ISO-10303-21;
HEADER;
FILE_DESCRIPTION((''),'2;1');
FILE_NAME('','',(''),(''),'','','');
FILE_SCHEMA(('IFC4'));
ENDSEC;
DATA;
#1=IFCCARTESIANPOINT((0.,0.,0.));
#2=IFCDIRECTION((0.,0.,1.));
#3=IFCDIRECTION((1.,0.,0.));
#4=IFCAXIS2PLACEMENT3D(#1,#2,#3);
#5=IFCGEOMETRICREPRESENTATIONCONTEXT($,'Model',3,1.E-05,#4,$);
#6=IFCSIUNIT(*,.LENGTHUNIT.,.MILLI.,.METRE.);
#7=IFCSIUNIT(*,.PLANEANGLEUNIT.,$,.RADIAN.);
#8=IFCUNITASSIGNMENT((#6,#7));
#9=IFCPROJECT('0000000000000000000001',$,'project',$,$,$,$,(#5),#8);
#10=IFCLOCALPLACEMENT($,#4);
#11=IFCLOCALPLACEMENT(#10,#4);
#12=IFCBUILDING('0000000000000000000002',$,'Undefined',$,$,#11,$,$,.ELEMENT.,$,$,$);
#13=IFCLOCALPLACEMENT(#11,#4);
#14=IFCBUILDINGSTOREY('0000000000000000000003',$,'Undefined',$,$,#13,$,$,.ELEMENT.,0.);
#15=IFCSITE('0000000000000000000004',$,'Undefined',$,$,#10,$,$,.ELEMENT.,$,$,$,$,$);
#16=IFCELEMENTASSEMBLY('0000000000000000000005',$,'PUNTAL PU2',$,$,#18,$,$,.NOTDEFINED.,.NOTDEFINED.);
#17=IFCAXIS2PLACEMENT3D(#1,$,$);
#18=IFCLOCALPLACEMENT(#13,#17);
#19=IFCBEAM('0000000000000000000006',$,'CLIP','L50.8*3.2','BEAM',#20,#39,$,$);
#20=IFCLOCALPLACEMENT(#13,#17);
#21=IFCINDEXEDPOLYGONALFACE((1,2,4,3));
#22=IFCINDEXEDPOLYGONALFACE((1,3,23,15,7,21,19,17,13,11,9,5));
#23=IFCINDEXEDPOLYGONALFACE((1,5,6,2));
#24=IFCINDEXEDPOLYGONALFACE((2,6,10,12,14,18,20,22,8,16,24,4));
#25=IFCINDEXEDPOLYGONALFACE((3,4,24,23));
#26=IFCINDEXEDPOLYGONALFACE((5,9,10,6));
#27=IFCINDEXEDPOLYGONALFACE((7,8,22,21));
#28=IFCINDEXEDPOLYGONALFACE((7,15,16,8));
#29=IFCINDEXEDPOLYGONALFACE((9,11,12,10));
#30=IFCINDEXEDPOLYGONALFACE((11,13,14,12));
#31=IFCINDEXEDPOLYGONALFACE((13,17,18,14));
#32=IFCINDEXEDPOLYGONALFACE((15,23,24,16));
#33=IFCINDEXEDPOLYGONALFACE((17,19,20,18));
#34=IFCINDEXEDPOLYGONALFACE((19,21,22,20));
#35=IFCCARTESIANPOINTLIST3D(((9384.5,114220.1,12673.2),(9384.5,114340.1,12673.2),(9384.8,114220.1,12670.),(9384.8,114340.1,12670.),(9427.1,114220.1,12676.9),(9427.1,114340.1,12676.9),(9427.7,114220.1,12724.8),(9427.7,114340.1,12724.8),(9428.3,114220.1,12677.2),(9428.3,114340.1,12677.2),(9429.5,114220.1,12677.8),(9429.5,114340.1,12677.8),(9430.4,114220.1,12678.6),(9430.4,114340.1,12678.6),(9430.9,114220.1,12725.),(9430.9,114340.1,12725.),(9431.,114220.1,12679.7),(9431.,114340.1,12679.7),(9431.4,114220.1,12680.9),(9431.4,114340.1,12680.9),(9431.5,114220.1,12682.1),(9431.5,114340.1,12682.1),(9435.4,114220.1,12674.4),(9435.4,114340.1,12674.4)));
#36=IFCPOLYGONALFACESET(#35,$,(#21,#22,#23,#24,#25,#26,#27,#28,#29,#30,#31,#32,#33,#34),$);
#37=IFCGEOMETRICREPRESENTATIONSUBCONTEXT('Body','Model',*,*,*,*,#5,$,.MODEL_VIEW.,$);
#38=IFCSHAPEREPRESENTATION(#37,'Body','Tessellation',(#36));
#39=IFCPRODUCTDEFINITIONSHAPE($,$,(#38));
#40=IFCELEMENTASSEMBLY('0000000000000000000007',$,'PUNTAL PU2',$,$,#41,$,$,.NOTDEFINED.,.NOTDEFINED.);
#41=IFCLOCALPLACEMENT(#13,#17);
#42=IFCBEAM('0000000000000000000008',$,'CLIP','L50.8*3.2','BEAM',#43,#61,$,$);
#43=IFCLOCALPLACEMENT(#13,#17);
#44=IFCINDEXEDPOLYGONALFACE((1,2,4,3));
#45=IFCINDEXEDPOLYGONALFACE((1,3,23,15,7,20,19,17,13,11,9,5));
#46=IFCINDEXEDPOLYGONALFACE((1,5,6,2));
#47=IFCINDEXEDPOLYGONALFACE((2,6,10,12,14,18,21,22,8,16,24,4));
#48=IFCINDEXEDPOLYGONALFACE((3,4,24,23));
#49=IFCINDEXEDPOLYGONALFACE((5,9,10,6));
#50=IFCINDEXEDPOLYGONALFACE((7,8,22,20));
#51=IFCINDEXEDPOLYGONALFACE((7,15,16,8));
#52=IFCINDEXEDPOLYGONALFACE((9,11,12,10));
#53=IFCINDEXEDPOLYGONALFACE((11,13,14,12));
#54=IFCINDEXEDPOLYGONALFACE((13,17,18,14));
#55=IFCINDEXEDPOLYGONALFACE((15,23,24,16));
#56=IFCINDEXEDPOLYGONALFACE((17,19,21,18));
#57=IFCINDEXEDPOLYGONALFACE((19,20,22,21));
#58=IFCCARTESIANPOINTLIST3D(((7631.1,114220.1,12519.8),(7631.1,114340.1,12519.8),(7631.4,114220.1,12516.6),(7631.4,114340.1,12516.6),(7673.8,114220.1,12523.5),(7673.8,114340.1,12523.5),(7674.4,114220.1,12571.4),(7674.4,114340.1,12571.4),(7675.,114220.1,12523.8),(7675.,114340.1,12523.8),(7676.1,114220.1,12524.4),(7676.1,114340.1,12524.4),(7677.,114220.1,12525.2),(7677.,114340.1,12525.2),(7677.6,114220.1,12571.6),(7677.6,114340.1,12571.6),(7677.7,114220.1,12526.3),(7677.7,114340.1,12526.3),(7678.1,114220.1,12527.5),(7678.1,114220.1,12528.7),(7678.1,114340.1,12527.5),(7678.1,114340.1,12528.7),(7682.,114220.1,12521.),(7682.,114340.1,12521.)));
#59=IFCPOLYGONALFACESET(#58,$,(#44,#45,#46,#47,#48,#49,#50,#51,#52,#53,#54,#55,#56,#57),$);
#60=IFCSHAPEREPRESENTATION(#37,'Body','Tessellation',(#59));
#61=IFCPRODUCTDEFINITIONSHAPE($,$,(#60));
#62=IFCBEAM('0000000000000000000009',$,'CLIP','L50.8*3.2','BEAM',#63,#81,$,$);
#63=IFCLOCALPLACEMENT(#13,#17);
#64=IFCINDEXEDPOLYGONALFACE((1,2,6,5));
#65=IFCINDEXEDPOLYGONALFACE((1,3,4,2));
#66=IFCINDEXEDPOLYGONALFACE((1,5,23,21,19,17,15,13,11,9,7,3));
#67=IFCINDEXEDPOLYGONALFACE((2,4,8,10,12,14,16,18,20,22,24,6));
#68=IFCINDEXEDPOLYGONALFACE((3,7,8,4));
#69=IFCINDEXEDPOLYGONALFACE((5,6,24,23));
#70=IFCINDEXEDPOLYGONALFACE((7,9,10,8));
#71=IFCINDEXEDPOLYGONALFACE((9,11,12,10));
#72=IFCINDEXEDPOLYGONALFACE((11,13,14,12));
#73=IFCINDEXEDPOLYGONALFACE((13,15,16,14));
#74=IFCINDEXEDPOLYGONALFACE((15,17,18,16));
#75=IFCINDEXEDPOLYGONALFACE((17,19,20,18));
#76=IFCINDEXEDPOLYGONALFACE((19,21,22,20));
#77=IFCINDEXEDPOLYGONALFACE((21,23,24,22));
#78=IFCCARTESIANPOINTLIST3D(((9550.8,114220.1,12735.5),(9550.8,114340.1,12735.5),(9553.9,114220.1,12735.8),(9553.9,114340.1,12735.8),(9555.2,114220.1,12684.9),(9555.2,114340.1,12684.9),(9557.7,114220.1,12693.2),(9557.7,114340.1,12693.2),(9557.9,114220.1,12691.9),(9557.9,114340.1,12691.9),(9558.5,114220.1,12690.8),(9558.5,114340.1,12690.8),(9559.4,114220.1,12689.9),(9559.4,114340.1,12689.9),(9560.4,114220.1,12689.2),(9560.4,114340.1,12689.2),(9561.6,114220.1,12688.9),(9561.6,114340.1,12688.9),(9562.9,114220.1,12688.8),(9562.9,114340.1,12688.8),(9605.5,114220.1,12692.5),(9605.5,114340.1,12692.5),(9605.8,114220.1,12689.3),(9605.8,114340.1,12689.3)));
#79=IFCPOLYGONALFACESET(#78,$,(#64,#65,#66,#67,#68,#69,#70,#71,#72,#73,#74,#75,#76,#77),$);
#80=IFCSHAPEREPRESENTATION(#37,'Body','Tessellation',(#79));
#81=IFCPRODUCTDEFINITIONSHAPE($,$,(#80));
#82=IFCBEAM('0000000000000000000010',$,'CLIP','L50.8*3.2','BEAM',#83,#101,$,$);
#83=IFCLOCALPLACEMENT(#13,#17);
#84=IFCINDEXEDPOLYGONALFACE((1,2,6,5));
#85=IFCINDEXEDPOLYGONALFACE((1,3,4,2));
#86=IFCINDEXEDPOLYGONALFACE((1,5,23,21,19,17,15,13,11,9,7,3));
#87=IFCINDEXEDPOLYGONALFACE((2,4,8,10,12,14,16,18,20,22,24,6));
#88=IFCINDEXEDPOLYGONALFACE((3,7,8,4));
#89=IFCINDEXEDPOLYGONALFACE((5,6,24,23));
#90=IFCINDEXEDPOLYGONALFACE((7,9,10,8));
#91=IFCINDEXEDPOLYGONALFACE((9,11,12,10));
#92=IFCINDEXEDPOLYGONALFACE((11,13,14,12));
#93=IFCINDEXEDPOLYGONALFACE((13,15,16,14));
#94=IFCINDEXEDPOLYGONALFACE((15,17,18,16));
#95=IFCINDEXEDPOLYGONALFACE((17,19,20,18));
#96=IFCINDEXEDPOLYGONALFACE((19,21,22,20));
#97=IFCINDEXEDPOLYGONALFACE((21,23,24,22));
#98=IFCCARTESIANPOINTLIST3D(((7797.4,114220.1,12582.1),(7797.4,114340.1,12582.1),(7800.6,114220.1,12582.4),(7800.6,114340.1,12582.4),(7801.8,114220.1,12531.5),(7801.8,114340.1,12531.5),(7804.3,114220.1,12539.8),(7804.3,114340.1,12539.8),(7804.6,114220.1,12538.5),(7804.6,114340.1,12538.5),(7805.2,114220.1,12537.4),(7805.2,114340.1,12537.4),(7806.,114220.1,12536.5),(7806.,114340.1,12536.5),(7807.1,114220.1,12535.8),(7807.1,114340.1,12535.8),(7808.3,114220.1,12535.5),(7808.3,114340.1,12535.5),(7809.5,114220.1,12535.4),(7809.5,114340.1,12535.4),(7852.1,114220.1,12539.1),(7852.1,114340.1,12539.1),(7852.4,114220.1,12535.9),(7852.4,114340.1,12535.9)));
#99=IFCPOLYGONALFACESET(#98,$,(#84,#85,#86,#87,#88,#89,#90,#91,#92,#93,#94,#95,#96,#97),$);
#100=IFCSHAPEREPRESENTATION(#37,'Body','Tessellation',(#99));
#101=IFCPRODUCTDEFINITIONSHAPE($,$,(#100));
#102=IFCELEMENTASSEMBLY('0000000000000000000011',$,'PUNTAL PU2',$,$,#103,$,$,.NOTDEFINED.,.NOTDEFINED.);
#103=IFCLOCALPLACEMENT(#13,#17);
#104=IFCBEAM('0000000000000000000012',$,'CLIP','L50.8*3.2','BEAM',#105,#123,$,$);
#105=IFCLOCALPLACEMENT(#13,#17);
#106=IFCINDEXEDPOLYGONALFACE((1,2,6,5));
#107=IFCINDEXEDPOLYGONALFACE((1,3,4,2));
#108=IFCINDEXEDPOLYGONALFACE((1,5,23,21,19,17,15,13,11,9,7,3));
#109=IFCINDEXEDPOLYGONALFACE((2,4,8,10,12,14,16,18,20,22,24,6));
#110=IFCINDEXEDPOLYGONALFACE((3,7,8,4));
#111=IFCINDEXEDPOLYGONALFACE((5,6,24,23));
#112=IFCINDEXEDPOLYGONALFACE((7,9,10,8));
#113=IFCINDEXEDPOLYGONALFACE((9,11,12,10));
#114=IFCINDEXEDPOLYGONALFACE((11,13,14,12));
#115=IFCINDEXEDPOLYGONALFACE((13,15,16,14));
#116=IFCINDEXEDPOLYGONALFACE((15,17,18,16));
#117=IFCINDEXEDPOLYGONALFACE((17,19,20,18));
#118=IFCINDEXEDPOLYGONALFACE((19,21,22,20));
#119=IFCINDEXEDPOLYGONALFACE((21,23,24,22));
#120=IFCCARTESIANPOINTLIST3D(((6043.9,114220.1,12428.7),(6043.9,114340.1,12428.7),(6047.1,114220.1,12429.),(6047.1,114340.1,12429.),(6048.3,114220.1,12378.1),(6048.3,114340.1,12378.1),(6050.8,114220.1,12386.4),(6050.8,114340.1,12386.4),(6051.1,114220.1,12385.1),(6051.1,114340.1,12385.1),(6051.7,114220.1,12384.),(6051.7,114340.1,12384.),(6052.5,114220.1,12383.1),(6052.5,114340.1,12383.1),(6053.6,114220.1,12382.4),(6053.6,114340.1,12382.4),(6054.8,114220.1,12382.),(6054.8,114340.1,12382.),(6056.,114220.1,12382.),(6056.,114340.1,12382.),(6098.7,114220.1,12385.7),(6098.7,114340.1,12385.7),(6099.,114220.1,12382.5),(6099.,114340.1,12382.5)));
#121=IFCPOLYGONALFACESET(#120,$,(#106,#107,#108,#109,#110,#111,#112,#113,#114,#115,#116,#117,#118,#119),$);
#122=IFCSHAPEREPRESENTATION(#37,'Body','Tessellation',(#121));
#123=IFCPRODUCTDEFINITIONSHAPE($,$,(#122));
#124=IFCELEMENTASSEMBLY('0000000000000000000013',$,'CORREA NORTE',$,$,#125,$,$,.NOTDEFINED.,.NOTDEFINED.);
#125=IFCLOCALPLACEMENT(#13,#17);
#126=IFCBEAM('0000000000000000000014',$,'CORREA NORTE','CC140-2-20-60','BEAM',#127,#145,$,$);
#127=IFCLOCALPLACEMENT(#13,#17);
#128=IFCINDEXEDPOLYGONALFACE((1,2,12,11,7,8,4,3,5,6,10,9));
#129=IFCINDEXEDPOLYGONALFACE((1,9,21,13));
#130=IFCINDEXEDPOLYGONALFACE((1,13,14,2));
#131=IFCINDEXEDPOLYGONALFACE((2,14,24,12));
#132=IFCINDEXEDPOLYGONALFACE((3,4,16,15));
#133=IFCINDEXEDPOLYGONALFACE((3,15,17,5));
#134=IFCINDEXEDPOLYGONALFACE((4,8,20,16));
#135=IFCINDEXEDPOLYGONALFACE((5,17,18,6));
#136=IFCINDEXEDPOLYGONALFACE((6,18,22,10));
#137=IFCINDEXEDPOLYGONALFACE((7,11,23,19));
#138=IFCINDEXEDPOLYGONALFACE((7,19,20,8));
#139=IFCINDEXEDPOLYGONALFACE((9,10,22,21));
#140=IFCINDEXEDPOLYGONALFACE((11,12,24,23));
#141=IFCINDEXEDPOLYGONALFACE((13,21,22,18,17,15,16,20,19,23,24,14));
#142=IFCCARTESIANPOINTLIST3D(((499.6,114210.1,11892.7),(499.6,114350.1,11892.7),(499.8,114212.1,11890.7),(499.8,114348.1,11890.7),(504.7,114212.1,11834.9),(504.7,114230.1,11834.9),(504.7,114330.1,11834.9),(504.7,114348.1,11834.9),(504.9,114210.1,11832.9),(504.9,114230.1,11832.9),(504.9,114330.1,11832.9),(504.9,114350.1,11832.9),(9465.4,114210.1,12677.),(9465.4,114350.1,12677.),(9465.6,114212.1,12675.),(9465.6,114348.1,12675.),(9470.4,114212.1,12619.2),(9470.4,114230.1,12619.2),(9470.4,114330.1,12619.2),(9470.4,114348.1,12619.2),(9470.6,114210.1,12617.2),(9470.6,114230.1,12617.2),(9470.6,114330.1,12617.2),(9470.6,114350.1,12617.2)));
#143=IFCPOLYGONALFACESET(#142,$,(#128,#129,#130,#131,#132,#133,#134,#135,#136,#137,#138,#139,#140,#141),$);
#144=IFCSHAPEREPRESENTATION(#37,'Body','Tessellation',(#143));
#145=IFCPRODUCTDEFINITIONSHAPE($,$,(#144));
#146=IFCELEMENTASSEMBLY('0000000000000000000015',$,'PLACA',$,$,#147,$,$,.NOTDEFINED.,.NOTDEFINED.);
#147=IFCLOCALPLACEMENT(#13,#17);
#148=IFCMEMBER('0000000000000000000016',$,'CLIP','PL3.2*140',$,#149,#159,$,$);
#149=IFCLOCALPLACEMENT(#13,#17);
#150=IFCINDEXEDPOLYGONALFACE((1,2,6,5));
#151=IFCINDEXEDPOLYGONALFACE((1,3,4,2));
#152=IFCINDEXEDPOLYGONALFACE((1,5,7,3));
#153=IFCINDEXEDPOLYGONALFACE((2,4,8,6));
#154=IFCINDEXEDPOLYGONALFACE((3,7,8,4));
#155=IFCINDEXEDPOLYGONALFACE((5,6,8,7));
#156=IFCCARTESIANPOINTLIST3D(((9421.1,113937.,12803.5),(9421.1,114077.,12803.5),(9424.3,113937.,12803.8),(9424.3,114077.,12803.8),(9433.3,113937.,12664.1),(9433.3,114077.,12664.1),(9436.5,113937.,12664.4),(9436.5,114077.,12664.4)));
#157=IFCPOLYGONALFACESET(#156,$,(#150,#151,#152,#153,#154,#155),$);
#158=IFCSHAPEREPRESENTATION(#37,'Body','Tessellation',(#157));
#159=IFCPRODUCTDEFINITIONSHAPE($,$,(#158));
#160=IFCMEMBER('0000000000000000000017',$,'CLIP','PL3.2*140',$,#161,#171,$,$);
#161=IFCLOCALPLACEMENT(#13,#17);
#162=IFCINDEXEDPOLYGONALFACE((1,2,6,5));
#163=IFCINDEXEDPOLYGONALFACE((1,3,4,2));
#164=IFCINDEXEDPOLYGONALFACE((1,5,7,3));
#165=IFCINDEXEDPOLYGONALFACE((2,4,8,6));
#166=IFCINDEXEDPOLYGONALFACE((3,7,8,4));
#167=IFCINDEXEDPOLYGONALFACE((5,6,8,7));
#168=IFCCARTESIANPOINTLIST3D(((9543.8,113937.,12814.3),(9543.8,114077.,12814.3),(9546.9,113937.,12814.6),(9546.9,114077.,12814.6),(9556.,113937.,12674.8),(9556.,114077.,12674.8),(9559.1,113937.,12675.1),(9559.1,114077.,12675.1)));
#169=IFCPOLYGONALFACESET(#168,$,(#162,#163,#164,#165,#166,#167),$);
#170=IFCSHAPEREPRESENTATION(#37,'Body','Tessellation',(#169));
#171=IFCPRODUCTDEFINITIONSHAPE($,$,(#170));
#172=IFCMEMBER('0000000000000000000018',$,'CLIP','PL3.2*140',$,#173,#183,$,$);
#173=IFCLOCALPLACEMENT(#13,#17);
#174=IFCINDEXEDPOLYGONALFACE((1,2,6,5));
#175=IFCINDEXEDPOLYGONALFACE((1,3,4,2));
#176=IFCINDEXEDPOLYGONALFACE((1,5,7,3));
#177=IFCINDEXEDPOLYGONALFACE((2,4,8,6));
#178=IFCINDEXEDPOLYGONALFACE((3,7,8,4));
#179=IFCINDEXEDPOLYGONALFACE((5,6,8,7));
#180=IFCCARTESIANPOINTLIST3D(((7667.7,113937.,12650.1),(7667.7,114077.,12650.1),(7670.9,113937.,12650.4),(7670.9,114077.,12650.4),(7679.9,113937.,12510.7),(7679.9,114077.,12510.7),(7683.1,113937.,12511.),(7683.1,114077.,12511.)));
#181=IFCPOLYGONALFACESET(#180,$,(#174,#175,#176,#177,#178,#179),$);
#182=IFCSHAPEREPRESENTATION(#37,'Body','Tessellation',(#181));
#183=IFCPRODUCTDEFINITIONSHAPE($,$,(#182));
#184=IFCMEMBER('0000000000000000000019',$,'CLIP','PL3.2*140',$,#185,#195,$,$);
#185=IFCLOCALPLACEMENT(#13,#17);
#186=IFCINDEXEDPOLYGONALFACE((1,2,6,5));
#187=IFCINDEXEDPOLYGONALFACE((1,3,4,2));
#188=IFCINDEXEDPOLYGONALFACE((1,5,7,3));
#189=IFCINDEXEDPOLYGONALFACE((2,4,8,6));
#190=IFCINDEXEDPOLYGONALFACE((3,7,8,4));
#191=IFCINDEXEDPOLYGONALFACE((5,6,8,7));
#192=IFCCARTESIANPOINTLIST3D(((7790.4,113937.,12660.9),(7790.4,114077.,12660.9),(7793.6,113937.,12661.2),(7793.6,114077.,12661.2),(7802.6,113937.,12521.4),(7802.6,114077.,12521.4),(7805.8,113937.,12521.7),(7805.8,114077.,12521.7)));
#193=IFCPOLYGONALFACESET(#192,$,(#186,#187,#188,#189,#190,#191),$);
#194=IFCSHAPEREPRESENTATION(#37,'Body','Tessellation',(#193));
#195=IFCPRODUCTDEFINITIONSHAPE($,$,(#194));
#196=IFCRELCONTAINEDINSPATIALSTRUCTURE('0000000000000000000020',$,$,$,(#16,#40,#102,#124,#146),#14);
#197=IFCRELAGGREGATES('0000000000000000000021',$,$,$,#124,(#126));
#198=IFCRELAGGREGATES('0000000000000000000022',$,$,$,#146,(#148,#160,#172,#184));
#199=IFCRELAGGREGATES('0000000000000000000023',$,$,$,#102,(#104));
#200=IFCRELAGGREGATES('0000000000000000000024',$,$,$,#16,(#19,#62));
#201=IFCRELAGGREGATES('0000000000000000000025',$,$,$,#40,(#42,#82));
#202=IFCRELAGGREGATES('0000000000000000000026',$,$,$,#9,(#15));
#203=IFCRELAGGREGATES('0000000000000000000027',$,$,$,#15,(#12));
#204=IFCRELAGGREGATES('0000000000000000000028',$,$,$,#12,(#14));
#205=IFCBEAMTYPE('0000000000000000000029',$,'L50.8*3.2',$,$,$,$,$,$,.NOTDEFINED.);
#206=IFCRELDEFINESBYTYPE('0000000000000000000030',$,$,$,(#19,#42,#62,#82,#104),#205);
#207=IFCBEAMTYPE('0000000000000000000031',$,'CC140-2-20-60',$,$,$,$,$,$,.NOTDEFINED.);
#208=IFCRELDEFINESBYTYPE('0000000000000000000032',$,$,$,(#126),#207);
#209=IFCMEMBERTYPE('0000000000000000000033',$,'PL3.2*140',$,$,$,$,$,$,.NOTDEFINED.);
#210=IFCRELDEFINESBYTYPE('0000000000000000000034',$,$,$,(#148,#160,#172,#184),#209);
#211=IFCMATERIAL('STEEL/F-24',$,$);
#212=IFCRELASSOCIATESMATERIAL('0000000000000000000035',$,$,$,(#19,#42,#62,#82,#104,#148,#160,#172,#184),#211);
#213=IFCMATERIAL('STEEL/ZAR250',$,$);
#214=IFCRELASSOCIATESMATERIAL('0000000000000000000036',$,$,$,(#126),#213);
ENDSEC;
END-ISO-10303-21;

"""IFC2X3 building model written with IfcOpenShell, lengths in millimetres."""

from ifc_helpers import new_model, si_unit, frame, origin_with_axes, origin_2d_with_axis, place, context, subcontext, project, spatial, rectangle, l_section, c_section, extrude, material, type_object, element, aggregate, save


model = new_model("IFC2X3")

# Units and contexts
model_context = context("Model", 3, precision=1e-05, world=origin_with_axes())
body_context = subcontext(model_context, "Body", "Model", "MODEL_VIEW")
ifc_project = project(units=[si_unit("LENGTHUNIT", "METRE", prefix="MILLI"), si_unit("PLANEANGLEUNIT", "RADIAN")], contexts=[model_context])

# Site, building, storey
site_placement = place(None, origin_with_axes())
site = spatial("IfcSite", under=ifc_project, at=site_placement, Name="Undefined", CompositionType="ELEMENT")
building_placement = place(site_placement, origin_with_axes())
building = spatial("IfcBuilding", under=site, at=building_placement, Name="Undefined", CompositionType="ELEMENT")
storey_placement = place(building_placement, origin_with_axes())
storey = spatial("IfcBuildingStorey", under=building, at=storey_placement, Name="Undefined", CompositionType="ELEMENT", Elevation=0.0)

# Element assemblies, beams
assembly_1_placement = place(storey_placement, origin_with_axes())
assembly_1 = element("IfcElementAssembly", 1, at=assembly_1_placement, inside=storey, Name="PUNTAL PU2", AssemblyPlace="NOTDEFINED", PredefinedType="NOTDEFINED")
ifc_material_1 = material(Name="STEEL/F-24")
beam_type_1 = type_object("IfcBeamType", Name="L50.8*3.2", PredefinedType="NOTDEFINED")
beam_1_placement = place(assembly_1_placement, frame((9407.8, 114340.1, 12697.5), z_axis=(-0.087156, 0.0, 0.996195), x_axis=(0.0, -1.0, 0.0)))
beam_1 = element("IfcBeam", 2, at=beam_1_placement, type_object=beam_type_1, material=ifc_material_1, Name="CLIP", Description="L50.8*3.2", ObjectType="BEAM", context=body_context, shape_type="SweptSolid", body=[
    extrude(l_section(Depth=50.8, Width=50.8, Thickness=3.2, FilletRadius=4.8, at=origin_2d_with_axis()), frame((120.0, 0.0, 0.0), z_axis=(-1.0, 0.0, 0.0), x_axis=(0.0, -1.0, 0.0)), (0.0, 0.0, 1.0), 120.0),
])
assembly_2_placement = place(storey_placement, origin_with_axes())
assembly_2 = element("IfcElementAssembly", 3, at=assembly_2_placement, inside=storey, Name="PUNTAL PU2", AssemblyPlace="NOTDEFINED", PredefinedType="NOTDEFINED")
beam_2_placement = place(assembly_2_placement, frame((7654.5, 114340.1, 12544.1), z_axis=(-0.087156, 0.0, 0.996195), x_axis=(0.0, -1.0, 0.0)))
beam_2 = element("IfcBeam", 4, at=beam_2_placement, type_object=beam_type_1, material=ifc_material_1, Name="CLIP", Description="L50.8*3.2", ObjectType="BEAM", context=body_context, shape_type="SweptSolid", body=[
    extrude(l_section(Depth=50.8, Width=50.8, Thickness=3.2, FilletRadius=4.8, at=origin_2d_with_axis()), frame((120.0, 0.0, 0.0), z_axis=(-1.0, 0.0, 0.0), x_axis=(0.0, -1.0, 0.0)), (0.0, 0.0, 1.0), 120.0),
])

# Beams
beam_3_placement = place(assembly_1_placement, frame((9578.3, 114220.1, 12712.4), z_axis=(-0.087156, 0.0, 0.996195), x_axis=(0.0, 1.0, 0.0)))
beam_3 = element("IfcBeam", 5, at=beam_3_placement, type_object=beam_type_1, material=ifc_material_1, Name="CLIP", Description="L50.8*3.2", ObjectType="BEAM", context=body_context, shape_type="SweptSolid", body=[
    extrude(l_section(Depth=50.8, Width=50.8, Thickness=3.2, FilletRadius=4.8, at=origin_2d_with_axis()), frame((120.0, 0.0, 0.0), z_axis=(-1.0, 0.0, 0.0), x_axis=(0.0, -1.0, 0.0)), (0.0, 0.0, 1.0), 120.0),
])
beam_4_placement = place(assembly_2_placement, frame((7824.9, 114220.1, 12559.0), z_axis=(-0.087156, 0.0, 0.996195), x_axis=(0.0, 1.0, 0.0)))
beam_4 = element("IfcBeam", 6, at=beam_4_placement, type_object=beam_type_1, material=ifc_material_1, Name="CLIP", Description="L50.8*3.2", ObjectType="BEAM", context=body_context, shape_type="SweptSolid", body=[
    extrude(l_section(Depth=50.8, Width=50.8, Thickness=3.2, FilletRadius=4.8, at=origin_2d_with_axis()), frame((120.0, 0.0, 0.0), z_axis=(-1.0, 0.0, 0.0), x_axis=(0.0, -1.0, 0.0)), (0.0, 0.0, 1.0), 120.0),
])

# Element assemblies, beams
assembly_3_placement = place(storey_placement, origin_with_axes())
assembly_3 = element("IfcElementAssembly", 7, at=assembly_3_placement, inside=storey, Name="PUNTAL PU2", AssemblyPlace="NOTDEFINED", PredefinedType="NOTDEFINED")
beam_5_placement = place(assembly_3_placement, frame((6071.4, 114220.1, 12405.6), z_axis=(-0.087156, 0.0, 0.996195), x_axis=(0.0, 1.0, 0.0)))
beam_5 = element("IfcBeam", 8, at=beam_5_placement, type_object=beam_type_1, material=ifc_material_1, Name="CLIP", Description="L50.8*3.2", ObjectType="BEAM", context=body_context, shape_type="SweptSolid", body=[
    extrude(l_section(Depth=50.8, Width=50.8, Thickness=3.2, FilletRadius=4.8, at=origin_2d_with_axis()), frame((120.0, 0.0, 0.0), z_axis=(-1.0, 0.0, 0.0), x_axis=(0.0, -1.0, 0.0)), (0.0, 0.0, 1.0), 120.0),
])
assembly_4_placement = place(storey_placement, origin_with_axes())
assembly_4 = element("IfcElementAssembly", 9, at=assembly_4_placement, inside=storey, Name="CORREA NORTE", AssemblyPlace="NOTDEFINED", PredefinedType="NOTDEFINED")
ifc_material_2 = material(Name="STEEL/ZAR250")
beam_type_2 = type_object("IfcBeamType", Name="CC140-2-20-60", PredefinedType="NOTDEFINED")
beam_6_placement = place(assembly_4_placement, frame((9468.0, 114280.1, 12647.1), z_axis=(0.0, 1.0, 0.0), x_axis=(-0.996195, 0.0, -0.087147)))
beam_6 = element("IfcBeam", 10, at=beam_6_placement, type_object=beam_type_2, material=ifc_material_2, Name="CORREA NORTE", Description="CC140-2-20-60", ObjectType="BEAM", context=body_context, shape_type="SweptSolid", body=[
    extrude(c_section(Depth=140.0, Width=60.0, WallThickness=2.0, Girth=20.0, at=origin_2d_with_axis()), frame((9000.0, 0.0, 0.0), z_axis=(-1.0, 0.0, 0.0), x_axis=(0.0, -1.0, 0.0)), (0.0, 0.0, 1.0), 9000.0),
])
aggregate(assembly_4, [beam_6])

# Element assembly, members
assembly_5_placement = place(storey_placement, origin_with_axes())
assembly_5 = element("IfcElementAssembly", 11, at=assembly_5_placement, inside=storey, Name="PLACA", AssemblyPlace="NOTDEFINED", PredefinedType="NOTDEFINED")
member_type = type_object("IfcMemberType", Name="PL3.2*140", PredefinedType="NOTDEFINED")
member_1_placement = place(assembly_5_placement, frame((9422.7, 114007.0, 12803.7), z_axis=(0.0, -1.0, 0.0), x_axis=(0.087155, 0.0, -0.996195)))
member_1 = element("IfcMember", 12, at=member_1_placement, type_object=member_type, material=ifc_material_1, Name="CLIP", Description="PL3.2*140", context=body_context, shape_type="SweptSolid", body=[
    extrude(rectangle(XDim=3.2, YDim=140.0, at=origin_2d_with_axis()), frame((140.0, 0.0, 0.0), z_axis=(-1.0, 0.0, 0.0), x_axis=(0.0, -1.0, 0.0)), (0.0, 0.0, 1.0), 140.0),
])
member_2_placement = place(assembly_5_placement, frame((9545.4, 114007.0, 12814.4), z_axis=(0.0, -1.0, 0.0), x_axis=(0.087155, 0.0, -0.996195)))
member_2 = element("IfcMember", 13, at=member_2_placement, type_object=member_type, material=ifc_material_1, Name="CLIP", Description="PL3.2*140", context=body_context, shape_type="SweptSolid", body=[
    extrude(rectangle(XDim=3.2, YDim=140.0, at=origin_2d_with_axis()), frame((140.0, 0.0, 0.0), z_axis=(-1.0, 0.0, 0.0), x_axis=(0.0, -1.0, 0.0)), (0.0, 0.0, 1.0), 140.0),
])
member_3_placement = place(assembly_5_placement, frame((7669.3, 114007.0, 12650.3), z_axis=(0.0, -1.0, 0.0), x_axis=(0.087155, 0.0, -0.996195)))
member_3 = element("IfcMember", 14, at=member_3_placement, type_object=member_type, material=ifc_material_1, Name="CLIP", Description="PL3.2*140", context=body_context, shape_type="SweptSolid", body=[
    extrude(rectangle(XDim=3.2, YDim=140.0, at=origin_2d_with_axis()), frame((140.0, 0.0, 0.0), z_axis=(-1.0, 0.0, 0.0), x_axis=(0.0, -1.0, 0.0)), (0.0, 0.0, 1.0), 140.0),
])
member_4_placement = place(assembly_5_placement, frame((7792.0, 114007.0, 12661.0), z_axis=(0.0, -1.0, 0.0), x_axis=(0.087155, 0.0, -0.996195)))
member_4 = element("IfcMember", 15, at=member_4_placement, type_object=member_type, material=ifc_material_1, Name="CLIP", Description="PL3.2*140", context=body_context, shape_type="SweptSolid", body=[
    extrude(rectangle(XDim=3.2, YDim=140.0, at=origin_2d_with_axis()), frame((140.0, 0.0, 0.0), z_axis=(-1.0, 0.0, 0.0), x_axis=(0.0, -1.0, 0.0)), (0.0, 0.0, 1.0), 140.0),
])
aggregate(assembly_5, [member_1, member_2, member_3, member_4])

aggregate(assembly_3, [beam_5])
aggregate(assembly_1, [beam_1, beam_3])
aggregate(assembly_2, [beam_2, beam_4])

save(model, "model.ifc")
